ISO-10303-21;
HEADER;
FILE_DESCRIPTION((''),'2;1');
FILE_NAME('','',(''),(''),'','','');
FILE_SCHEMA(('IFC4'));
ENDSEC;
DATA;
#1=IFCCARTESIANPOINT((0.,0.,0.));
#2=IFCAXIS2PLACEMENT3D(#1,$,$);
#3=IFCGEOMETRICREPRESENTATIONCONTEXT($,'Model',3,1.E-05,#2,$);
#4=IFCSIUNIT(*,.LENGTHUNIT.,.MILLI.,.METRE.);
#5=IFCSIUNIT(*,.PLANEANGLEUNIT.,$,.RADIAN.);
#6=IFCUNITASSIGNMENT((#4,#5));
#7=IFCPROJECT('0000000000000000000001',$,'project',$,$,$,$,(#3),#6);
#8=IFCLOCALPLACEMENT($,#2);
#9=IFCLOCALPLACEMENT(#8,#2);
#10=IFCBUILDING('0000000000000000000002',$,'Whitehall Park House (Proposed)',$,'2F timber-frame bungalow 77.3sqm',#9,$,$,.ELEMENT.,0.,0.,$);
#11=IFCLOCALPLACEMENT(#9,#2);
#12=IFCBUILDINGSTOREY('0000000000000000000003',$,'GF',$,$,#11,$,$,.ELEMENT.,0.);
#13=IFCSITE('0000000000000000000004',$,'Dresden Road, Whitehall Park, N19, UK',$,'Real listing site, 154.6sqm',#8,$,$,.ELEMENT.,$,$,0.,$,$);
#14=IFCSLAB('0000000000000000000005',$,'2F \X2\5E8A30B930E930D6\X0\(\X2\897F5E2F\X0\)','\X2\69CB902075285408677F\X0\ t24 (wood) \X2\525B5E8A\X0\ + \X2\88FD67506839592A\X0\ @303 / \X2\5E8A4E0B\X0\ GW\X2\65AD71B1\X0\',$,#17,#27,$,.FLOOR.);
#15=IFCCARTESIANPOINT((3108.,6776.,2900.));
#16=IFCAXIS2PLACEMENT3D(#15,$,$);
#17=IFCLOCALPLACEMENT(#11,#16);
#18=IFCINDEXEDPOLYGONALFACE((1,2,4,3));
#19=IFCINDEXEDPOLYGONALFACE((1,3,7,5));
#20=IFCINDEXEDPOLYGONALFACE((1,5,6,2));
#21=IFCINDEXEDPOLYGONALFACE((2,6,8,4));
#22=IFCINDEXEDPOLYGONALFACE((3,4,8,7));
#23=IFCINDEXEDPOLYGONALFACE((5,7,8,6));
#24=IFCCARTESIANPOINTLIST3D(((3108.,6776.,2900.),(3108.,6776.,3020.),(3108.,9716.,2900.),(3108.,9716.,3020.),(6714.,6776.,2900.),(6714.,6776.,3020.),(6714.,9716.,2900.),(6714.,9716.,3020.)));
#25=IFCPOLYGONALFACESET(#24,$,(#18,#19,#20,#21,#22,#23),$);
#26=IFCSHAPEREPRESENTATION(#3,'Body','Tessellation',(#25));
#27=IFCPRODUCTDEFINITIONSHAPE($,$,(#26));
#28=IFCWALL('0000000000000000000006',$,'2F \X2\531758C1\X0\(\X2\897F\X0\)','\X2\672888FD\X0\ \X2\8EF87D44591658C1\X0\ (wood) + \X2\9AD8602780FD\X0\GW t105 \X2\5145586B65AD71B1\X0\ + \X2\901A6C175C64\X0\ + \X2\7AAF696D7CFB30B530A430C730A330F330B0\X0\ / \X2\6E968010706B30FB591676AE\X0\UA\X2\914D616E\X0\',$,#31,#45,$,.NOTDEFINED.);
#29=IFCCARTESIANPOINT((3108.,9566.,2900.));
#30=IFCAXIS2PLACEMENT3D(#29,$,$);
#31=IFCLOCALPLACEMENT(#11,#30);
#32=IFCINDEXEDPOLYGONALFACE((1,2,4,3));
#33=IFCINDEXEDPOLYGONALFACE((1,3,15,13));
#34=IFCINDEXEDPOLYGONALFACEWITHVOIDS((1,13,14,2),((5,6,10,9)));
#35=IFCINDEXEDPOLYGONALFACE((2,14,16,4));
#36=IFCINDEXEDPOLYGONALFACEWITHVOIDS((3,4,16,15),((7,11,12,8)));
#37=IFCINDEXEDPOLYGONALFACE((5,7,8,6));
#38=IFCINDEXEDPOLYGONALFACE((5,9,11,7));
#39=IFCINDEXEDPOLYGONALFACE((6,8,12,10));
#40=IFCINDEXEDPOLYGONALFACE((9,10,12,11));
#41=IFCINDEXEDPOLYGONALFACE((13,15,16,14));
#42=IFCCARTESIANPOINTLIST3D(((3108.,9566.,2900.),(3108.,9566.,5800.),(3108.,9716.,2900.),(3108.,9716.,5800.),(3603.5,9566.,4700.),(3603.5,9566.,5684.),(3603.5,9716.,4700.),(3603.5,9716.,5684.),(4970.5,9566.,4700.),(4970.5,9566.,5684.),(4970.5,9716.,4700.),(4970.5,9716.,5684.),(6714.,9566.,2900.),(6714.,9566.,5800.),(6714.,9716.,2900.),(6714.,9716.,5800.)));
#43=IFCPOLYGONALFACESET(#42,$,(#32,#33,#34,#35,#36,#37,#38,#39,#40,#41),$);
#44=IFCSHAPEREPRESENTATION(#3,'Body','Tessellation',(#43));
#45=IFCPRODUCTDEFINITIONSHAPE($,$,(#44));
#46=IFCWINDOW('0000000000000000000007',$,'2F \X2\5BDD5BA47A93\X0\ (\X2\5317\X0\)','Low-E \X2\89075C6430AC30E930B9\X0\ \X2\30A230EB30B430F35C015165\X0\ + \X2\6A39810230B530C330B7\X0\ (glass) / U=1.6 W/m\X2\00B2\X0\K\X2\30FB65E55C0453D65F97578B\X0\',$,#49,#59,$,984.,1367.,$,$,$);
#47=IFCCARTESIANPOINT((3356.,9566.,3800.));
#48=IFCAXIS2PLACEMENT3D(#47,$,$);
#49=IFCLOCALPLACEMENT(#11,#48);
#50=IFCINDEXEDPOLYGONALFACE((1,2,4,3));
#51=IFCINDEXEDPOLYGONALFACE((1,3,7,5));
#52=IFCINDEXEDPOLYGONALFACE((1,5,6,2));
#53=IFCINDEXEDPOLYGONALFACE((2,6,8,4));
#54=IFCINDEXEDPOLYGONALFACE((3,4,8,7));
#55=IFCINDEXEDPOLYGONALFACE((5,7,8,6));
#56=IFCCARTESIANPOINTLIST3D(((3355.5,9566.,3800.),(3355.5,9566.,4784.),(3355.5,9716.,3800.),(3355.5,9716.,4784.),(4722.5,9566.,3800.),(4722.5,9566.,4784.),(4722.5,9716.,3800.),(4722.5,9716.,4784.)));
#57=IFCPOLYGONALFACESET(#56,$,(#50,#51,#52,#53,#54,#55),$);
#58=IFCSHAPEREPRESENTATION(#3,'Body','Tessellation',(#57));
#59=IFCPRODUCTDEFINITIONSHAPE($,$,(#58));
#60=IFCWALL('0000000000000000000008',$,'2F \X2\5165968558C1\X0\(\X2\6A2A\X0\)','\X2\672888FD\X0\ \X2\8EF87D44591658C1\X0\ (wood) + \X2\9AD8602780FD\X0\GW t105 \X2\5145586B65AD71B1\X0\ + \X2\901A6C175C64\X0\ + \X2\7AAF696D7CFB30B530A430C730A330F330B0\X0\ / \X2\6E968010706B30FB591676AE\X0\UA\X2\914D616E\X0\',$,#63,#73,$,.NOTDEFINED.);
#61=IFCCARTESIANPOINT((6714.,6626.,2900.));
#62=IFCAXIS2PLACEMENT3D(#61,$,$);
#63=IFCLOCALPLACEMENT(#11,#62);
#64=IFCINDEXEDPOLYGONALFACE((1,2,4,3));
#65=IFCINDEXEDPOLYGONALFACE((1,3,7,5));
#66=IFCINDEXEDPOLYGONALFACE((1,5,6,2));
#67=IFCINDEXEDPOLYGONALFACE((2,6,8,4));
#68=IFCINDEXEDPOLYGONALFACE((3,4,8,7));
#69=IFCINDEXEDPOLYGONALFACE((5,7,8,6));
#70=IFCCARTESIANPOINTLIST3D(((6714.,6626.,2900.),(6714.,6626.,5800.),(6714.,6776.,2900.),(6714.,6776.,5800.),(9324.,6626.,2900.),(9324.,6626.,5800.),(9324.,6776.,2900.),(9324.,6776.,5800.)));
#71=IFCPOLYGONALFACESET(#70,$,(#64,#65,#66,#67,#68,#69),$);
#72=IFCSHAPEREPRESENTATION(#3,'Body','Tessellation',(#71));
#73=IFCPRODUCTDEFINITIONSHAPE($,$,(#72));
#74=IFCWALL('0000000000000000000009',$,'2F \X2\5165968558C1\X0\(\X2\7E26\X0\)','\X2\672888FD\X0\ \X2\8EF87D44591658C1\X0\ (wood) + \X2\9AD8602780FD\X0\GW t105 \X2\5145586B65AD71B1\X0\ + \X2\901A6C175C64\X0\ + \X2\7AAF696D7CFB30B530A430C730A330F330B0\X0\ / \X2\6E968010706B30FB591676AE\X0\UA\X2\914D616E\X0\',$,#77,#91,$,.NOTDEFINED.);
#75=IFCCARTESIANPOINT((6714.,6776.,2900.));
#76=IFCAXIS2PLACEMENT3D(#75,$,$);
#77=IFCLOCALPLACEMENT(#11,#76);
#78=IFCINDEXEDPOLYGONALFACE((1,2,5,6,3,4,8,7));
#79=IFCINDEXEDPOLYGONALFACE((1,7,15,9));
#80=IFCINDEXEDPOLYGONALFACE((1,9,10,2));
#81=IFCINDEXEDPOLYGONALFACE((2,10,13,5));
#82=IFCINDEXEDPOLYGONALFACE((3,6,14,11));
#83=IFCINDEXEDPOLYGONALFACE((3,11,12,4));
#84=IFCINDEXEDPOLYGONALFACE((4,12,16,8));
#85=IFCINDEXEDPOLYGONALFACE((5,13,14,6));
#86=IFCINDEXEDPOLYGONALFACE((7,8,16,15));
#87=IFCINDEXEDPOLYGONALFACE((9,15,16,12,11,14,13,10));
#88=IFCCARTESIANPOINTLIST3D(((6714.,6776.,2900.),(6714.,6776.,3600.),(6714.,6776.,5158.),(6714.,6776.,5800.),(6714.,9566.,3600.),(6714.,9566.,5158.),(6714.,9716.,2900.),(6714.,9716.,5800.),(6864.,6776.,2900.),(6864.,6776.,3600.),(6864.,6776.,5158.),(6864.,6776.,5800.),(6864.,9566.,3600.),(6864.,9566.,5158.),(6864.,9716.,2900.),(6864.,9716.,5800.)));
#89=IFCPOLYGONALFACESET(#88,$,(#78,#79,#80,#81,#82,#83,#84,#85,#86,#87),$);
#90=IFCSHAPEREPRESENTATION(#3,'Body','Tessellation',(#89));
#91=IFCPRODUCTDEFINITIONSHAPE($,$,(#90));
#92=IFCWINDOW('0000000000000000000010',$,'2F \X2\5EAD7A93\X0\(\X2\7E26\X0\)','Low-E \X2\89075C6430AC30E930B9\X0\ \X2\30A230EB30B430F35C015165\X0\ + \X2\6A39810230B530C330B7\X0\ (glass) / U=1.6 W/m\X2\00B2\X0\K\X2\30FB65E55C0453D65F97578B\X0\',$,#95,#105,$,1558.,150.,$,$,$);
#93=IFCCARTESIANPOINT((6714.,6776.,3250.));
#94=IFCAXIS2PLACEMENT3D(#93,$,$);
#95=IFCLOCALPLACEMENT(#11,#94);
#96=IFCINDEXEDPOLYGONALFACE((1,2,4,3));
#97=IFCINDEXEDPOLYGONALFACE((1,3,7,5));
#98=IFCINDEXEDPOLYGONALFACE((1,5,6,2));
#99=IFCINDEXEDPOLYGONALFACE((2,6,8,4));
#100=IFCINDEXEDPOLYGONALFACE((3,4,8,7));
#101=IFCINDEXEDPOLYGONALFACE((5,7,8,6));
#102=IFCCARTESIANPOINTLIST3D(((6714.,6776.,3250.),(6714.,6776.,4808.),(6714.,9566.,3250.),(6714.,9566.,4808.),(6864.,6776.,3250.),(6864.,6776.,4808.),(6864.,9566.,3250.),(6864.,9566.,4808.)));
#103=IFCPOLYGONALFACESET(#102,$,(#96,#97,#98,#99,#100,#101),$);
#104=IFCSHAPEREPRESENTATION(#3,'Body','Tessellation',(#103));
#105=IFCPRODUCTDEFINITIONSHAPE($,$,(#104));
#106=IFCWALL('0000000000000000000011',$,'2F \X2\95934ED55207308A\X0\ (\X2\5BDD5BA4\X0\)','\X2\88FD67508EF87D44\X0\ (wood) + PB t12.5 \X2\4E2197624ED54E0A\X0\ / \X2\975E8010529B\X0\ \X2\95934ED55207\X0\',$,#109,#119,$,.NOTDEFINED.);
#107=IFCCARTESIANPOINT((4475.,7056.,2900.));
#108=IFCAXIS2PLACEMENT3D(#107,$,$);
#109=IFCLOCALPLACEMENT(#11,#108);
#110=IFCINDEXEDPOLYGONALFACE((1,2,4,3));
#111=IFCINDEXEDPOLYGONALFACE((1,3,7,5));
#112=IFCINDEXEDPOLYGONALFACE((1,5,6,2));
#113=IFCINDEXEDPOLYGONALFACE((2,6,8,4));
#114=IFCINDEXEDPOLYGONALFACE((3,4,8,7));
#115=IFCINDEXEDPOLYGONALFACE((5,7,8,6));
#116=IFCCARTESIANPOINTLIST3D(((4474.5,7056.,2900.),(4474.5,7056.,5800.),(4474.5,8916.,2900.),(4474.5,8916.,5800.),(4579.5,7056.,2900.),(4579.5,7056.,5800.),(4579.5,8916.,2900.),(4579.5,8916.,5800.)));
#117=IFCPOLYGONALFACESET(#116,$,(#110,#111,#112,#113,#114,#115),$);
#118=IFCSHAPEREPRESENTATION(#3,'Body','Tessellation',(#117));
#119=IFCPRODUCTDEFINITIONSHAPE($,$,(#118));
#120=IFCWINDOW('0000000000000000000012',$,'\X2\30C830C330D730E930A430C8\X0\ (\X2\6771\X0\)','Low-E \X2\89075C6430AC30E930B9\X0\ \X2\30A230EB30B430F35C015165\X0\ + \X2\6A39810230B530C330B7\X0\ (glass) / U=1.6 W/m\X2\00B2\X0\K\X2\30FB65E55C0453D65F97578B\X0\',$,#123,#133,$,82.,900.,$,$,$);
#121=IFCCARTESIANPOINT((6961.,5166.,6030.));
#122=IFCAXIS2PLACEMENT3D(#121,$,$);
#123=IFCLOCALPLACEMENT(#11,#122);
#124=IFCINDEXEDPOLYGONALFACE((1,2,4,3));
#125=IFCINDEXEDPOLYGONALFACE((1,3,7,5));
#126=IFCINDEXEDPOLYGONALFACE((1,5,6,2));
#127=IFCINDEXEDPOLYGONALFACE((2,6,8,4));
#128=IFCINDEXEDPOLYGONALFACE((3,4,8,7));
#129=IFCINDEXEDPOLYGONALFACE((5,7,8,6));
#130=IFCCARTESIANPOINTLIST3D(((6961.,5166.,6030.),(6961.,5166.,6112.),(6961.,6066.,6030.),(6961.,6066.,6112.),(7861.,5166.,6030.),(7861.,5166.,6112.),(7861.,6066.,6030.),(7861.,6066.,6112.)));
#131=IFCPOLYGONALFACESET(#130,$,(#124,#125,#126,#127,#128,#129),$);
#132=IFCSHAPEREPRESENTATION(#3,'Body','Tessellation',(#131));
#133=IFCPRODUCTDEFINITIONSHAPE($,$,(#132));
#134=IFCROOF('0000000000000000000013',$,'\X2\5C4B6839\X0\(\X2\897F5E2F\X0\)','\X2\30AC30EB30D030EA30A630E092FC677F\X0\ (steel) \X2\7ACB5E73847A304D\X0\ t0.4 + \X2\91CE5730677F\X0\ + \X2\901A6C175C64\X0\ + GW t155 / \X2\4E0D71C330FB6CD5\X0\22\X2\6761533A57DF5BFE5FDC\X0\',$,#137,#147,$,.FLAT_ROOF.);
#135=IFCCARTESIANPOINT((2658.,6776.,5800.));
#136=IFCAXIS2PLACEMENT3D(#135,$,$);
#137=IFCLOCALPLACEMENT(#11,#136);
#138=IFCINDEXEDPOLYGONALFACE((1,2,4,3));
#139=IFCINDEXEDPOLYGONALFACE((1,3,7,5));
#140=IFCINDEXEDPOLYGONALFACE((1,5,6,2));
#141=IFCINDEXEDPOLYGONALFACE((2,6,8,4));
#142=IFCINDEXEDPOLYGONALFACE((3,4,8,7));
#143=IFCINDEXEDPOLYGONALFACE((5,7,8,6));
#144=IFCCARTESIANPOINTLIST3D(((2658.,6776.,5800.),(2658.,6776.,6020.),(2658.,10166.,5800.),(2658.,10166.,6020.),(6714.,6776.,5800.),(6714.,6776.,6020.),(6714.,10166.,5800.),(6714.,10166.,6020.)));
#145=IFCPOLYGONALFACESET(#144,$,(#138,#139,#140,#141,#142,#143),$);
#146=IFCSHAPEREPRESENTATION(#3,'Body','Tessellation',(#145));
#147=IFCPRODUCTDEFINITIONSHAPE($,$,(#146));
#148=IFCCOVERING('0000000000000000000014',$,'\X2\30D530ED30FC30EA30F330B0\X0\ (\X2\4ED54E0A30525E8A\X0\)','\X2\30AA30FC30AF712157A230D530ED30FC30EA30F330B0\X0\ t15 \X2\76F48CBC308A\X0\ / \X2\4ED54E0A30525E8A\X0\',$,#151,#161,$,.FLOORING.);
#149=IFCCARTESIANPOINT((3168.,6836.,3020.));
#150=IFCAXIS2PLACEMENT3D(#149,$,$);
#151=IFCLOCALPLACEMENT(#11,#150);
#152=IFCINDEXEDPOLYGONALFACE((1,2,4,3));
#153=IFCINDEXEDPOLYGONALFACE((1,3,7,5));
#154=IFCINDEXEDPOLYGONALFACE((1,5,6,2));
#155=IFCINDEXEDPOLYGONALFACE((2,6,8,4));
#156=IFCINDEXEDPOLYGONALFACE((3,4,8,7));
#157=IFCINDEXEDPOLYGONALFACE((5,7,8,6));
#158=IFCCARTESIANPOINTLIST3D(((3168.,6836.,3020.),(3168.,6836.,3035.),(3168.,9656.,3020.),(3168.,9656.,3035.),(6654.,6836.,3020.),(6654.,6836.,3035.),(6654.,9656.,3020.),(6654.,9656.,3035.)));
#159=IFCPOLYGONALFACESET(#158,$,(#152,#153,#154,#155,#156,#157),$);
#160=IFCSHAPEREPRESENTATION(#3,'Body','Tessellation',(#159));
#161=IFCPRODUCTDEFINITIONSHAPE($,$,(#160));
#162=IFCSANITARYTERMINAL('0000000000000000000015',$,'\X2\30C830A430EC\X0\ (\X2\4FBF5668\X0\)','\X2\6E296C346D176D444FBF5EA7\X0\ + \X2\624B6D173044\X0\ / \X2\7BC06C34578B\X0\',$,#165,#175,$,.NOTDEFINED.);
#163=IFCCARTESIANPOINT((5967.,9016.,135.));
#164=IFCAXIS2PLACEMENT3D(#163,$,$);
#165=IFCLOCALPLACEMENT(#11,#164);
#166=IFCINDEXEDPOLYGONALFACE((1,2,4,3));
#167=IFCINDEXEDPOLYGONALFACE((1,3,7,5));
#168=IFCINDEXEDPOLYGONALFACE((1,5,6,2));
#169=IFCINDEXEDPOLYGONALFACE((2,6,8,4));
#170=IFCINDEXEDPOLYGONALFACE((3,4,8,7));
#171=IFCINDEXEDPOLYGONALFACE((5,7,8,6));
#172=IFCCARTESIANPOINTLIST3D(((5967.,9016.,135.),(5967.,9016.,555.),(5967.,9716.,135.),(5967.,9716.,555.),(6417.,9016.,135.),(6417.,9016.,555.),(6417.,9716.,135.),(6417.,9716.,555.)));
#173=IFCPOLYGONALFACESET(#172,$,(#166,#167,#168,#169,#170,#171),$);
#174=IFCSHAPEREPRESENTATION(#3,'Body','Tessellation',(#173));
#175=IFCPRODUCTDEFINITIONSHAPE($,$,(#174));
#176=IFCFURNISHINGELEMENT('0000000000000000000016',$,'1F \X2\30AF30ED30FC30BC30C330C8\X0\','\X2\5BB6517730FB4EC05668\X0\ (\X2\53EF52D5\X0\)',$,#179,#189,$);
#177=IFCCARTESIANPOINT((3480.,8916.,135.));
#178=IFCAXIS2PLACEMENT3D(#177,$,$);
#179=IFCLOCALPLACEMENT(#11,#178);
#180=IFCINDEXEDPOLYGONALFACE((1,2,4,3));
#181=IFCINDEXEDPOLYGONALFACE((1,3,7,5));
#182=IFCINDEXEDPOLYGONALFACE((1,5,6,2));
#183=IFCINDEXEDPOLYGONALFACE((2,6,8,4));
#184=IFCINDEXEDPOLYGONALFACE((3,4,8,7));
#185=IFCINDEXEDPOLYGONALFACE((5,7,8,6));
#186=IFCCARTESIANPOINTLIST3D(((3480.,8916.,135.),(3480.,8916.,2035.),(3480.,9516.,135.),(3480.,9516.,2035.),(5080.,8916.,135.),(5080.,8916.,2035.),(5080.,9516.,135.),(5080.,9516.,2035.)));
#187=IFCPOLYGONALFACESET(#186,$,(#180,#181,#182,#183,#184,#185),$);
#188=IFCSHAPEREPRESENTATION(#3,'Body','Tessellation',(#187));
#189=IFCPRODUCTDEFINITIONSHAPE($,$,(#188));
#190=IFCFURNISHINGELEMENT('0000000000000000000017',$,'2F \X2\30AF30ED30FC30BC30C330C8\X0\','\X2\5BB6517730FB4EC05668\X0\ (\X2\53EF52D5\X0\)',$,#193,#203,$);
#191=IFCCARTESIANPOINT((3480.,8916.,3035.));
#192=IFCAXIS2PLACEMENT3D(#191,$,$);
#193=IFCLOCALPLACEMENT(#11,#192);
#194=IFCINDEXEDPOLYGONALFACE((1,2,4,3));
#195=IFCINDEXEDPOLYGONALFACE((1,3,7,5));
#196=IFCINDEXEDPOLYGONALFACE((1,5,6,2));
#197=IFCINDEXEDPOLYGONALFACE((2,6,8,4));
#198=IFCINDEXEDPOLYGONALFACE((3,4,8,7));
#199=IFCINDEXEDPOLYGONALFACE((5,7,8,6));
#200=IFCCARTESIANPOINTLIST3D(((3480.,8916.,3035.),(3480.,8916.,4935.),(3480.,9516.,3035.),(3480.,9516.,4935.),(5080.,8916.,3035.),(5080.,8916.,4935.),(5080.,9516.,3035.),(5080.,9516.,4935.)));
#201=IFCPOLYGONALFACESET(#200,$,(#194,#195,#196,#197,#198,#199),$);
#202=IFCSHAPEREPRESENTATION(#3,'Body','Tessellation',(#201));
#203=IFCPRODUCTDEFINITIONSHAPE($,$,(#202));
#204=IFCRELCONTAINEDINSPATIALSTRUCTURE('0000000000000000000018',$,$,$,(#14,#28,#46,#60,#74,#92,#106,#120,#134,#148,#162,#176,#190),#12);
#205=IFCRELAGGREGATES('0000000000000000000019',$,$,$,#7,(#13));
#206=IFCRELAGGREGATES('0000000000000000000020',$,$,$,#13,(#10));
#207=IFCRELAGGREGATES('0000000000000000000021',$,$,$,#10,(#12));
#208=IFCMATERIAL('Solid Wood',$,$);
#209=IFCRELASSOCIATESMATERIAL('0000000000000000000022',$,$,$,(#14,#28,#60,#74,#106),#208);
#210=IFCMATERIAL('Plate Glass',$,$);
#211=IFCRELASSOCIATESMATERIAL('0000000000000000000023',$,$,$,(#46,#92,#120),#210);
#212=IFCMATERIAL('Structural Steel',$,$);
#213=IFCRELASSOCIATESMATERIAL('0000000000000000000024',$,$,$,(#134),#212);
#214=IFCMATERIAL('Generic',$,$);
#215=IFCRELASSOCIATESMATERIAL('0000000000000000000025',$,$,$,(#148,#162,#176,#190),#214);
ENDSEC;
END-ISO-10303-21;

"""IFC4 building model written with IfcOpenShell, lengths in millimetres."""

from ifc_helpers import new_model, si_unit, frame, frame_2d, origin, place, context, project, spatial, rectangle, extrude, material, element, fill, save


model = new_model("IFC4")

# Units and contexts
model_context = context("Model", 3, precision=1e-05, world=origin())
ifc_project = project(units=[si_unit("LENGTHUNIT", "METRE", prefix="MILLI"), si_unit("PLANEANGLEUNIT", "RADIAN")], contexts=[model_context])

# Site, building, storey
site_placement = place(None, origin())
site = spatial("IfcSite", under=ifc_project, at=site_placement, Name="Dresden Road, Whitehall Park, N19, UK", ObjectType="Real listing site, 154.6sqm", CompositionType="ELEMENT", RefElevation=0.0)
building_placement = place(site_placement, origin())
building = spatial("IfcBuilding", under=site, at=building_placement, Name="Whitehall Park House (Proposed)", ObjectType="2F timber-frame bungalow 77.3sqm", CompositionType="ELEMENT", ElevationOfRefHeight=0.0, ElevationOfTerrain=0.0)
storey_placement = place(building_placement, origin())
storey = spatial("IfcBuildingStorey", under=building, at=storey_placement, Name="GF", CompositionType="ELEMENT", Elevation=0.0)

# Slab
ifc_material_1 = material(Name="Solid Wood")
slab_placement = place(storey_placement, frame((3108.0, 6776.0, 2900.0)))
element("IfcSlab", 1, at=slab_placement, inside=storey, material=ifc_material_1, Name="2F 床スラブ(西帯)", Description="構造用合板 t24 (wood) 剛床 + 製材根太 @303 / 床下 GW断熱", PredefinedType="FLOOR", context=model_context, shape_type="SweptSolid", body=[
    extrude(rectangle(XDim=3606.0, YDim=2940.0, at=frame_2d((1803.0, 1470.0))), frame((3108.0, 6776.0, 2900.0)), (0.0, 0.0, 1.0), 120.0),
])

# Wall, opening, window
wall_1_placement = place(storey_placement, frame((3108.0, 9566.0, 2900.0)))
wall_1 = element("IfcWall", 2, at=wall_1_placement, inside=storey, material=ifc_material_1, Name="2F 北壁(西)", Description="木製 軸組外壁 (wood) + 高性能GW t105 充填断熱 + 通気層 + 窯業系サイディング / 準耐火・外皮UA配慮", PredefinedType="NOTDEFINED", context=model_context, shape_type="SweptSolid", body=[
    extrude(rectangle(XDim=3606.0, YDim=150.0, at=frame_2d((1803.0, 75.0))), frame((3108.0, 9566.0, 2900.0)), (0.0, 0.0, 1.0), 2900.0),
])
opening_1_placement = place(storey_placement, frame((3356.0, 9566.0, 3800.0)))
opening_1 = element("IfcOpeningElement", 3, at=opening_1_placement, cuts=wall_1, PredefinedType="NOTDEFINED", context=model_context, shape_type="SweptSolid", body=[
    extrude(rectangle(XDim=1367.0, YDim=150.0, at=frame_2d((683.0, 75.0))), frame((3356.0, 9566.0, 3800.0)), (0.0, 0.0, 1.0), 984.0),
])
ifc_material_2 = material(Name="Plate Glass")
window_1_placement = place(storey_placement, frame((3356.0, 9566.0, 3800.0)))
window_1 = element("IfcWindow", 4, at=window_1_placement, inside=storey, material=ifc_material_2, Name="2F 寝室窓 (北)", Description="Low-E 複層ガラス アルゴン封入 + 樹脂サッシ (glass) / U=1.6 W/m²K・日射取得型", OverallHeight=984.0, OverallWidth=1367.0, context=model_context, shape_type="SweptSolid", body=[
    extrude(rectangle(XDim=1367.0, YDim=150.0, at=frame_2d((683.0, 75.0))), frame((3356.0, 9566.0, 3800.0)), (0.0, 0.0, 1.0), 984.0),
])
fill(opening_1, window_1)

# Wall
wall_2_placement = place(storey_placement, frame((6714.0, 6626.0, 2900.0)))
element("IfcWall", 5, at=wall_2_placement, inside=storey, material=ifc_material_1, Name="2F 入隅壁(横)", Description="木製 軸組外壁 (wood) + 高性能GW t105 充填断熱 + 通気層 + 窯業系サイディング / 準耐火・外皮UA配慮", PredefinedType="NOTDEFINED", context=model_context, shape_type="SweptSolid", body=[
    extrude(rectangle(XDim=2610.0, YDim=150.0, at=frame_2d((1305.0, 75.0))), frame((6714.0, 6626.0, 2900.0)), (0.0, 0.0, 1.0), 2900.0),
])

# Wall, opening, window
wall_3_placement = place(storey_placement, frame((6714.0, 6776.0, 2900.0)))
wall_3 = element("IfcWall", 6, at=wall_3_placement, inside=storey, material=ifc_material_1, Name="2F 入隅壁(縦)", Description="木製 軸組外壁 (wood) + 高性能GW t105 充填断熱 + 通気層 + 窯業系サイディング / 準耐火・外皮UA配慮", PredefinedType="NOTDEFINED", context=model_context, shape_type="SweptSolid", body=[
    extrude(rectangle(XDim=150.0, YDim=2940.0, at=frame_2d((75.0, 1470.0))), frame((6714.0, 6776.0, 2900.0)), (0.0, 0.0, 1.0), 2900.0),
])
opening_2_placement = place(storey_placement, frame((6714.0, 6776.0, 3250.0)))
opening_2 = element("IfcOpeningElement", 7, at=opening_2_placement, cuts=wall_3, PredefinedType="NOTDEFINED", context=model_context, shape_type="SweptSolid", body=[
    extrude(rectangle(XDim=150.0, YDim=2790.0, at=frame_2d((75.0, 1395.0))), frame((6714.0, 6776.0, 3250.0)), (0.0, 0.0, 1.0), 1558.0),
])
window_2_placement = place(storey_placement, frame((6714.0, 6776.0, 3250.0)))
window_2 = element("IfcWindow", 8, at=window_2_placement, inside=storey, material=ifc_material_2, Name="2F 庭窓(縦)", Description="Low-E 複層ガラス アルゴン封入 + 樹脂サッシ (glass) / U=1.6 W/m²K・日射取得型", OverallHeight=1558.0, OverallWidth=150.0, context=model_context, shape_type="SweptSolid", body=[
    extrude(rectangle(XDim=150.0, YDim=2790.0, at=frame_2d((75.0, 1395.0))), frame((6714.0, 6776.0, 3250.0)), (0.0, 0.0, 1.0), 1558.0),
])
fill(opening_2, window_2)

# Wall
wall_4_placement = place(storey_placement, frame((4475.0, 7056.0, 2900.0)))
element("IfcWall", 9, at=wall_4_placement, inside=storey, material=ifc_material_1, Name="2F 間仕切り (寝室)", Description="製材軸組 (wood) + PB t12.5 両面仕上 / 非耐力 間仕切", PredefinedType="NOTDEFINED", context=model_context, shape_type="SweptSolid", body=[
    extrude(rectangle(XDim=105.0, YDim=1860.0, at=frame_2d((52.0, 930.0))), frame((4475.0, 7056.0, 2900.0)), (0.0, 0.0, 1.0), 2900.0),
])

# Window
window_3_placement = place(storey_placement, frame((6961.0, 5166.0, 6030.0)))
element("IfcWindow", 10, at=window_3_placement, inside=storey, material=ifc_material_2, Name="トップライト (東)", Description="Low-E 複層ガラス アルゴン封入 + 樹脂サッシ (glass) / U=1.6 W/m²K・日射取得型", OverallHeight=82.0, OverallWidth=900.0, context=model_context, shape_type="SweptSolid", body=[
    extrude(rectangle(XDim=900.0, YDim=900.0, at=frame_2d((450.0, 450.0))), frame((6961.0, 5166.0, 6030.0)), (0.0, 0.0, 1.0), 82.0),
])

# Roof
ifc_material_3 = material(Name="Structural Steel")
for number, where, name in (
    (11, (2658.0, 6776.0, 5800.0), "屋根(西帯)"),
):
    element("IfcRoof", number, at=place(storey_placement, frame(where)), inside=storey, material=ifc_material_3, Name=name, Description="ガルバリウム鋼板 (steel) 立平葺き t0.4 + 野地板 + 通気層 + GW t155 / 不燃・法22条区域対応", PredefinedType="FLAT_ROOF", context=model_context, shape_type="SweptSolid", body=[
        extrude(rectangle(XDim=4056.0, YDim=3390.0, at=frame_2d((2028.0, 1695.0))), frame((2658.0, 6776.0, 5800.0)), (0.0, 0.0, 1.0), 220.0),
    ])

# Covering
ifc_material_4 = material(Name="Generic")
covering_placement = place(storey_placement, frame((3168.0, 6836.0, 3020.0)))
element("IfcCovering", 12, at=covering_placement, inside=storey, material=ifc_material_4, Name="フローリング (仕上げ床)", Description="オーク無垢フローリング t15 直貼り / 仕上げ床", PredefinedType="FLOORING", context=model_context, shape_type="SweptSolid", body=[
    extrude(rectangle(XDim=3486.0, YDim=2820.0, at=frame_2d((1743.0, 1410.0))), frame((3168.0, 6836.0, 3020.0)), (0.0, 0.0, 1.0), 15.0),
])

# Sanitary terminal
sanitary_terminal_placement = place(storey_placement, frame((5967.0, 9016.0, 135.0)))
element("IfcSanitaryTerminal", 13, at=sanitary_terminal_placement, inside=storey, material=ifc_material_4, Name="トイレ (便器)", Description="温水洗浄便座 + 手洗い / 節水型", PredefinedType="NOTDEFINED", context=model_context, shape_type="SweptSolid", body=[
    extrude(rectangle(XDim=450.0, YDim=700.0, at=frame_2d((225.0, 350.0))), frame((5967.0, 9016.0, 135.0)), (0.0, 0.0, 1.0), 420.0),
])

# Furnishing elements
furnishing_1_placement = place(storey_placement, frame((3480.0, 8916.0, 135.0)))
element("IfcFurnishingElement", 14, at=furnishing_1_placement, inside=storey, material=ifc_material_4, Name="1F クローゼット", Description="家具・什器 (可動)", context=model_context, shape_type="SweptSolid", body=[
    extrude(rectangle(XDim=1600.0, YDim=600.0, at=frame_2d((800.0, 300.0))), frame((3480.0, 8916.0, 135.0)), (0.0, 0.0, 1.0), 1900.0),
])
furnishing_2_placement = place(storey_placement, frame((3480.0, 8916.0, 3035.0)))
element("IfcFurnishingElement", 15, at=furnishing_2_placement, inside=storey, material=ifc_material_4, Name="2F クローゼット", Description="家具・什器 (可動)", context=model_context, shape_type="SweptSolid", body=[
    extrude(rectangle(XDim=1600.0, YDim=600.0, at=frame_2d((800.0, 300.0))), frame((3480.0, 8916.0, 3035.0)), (0.0, 0.0, 1.0), 1900.0),
])

save(model, "model.ifc")
